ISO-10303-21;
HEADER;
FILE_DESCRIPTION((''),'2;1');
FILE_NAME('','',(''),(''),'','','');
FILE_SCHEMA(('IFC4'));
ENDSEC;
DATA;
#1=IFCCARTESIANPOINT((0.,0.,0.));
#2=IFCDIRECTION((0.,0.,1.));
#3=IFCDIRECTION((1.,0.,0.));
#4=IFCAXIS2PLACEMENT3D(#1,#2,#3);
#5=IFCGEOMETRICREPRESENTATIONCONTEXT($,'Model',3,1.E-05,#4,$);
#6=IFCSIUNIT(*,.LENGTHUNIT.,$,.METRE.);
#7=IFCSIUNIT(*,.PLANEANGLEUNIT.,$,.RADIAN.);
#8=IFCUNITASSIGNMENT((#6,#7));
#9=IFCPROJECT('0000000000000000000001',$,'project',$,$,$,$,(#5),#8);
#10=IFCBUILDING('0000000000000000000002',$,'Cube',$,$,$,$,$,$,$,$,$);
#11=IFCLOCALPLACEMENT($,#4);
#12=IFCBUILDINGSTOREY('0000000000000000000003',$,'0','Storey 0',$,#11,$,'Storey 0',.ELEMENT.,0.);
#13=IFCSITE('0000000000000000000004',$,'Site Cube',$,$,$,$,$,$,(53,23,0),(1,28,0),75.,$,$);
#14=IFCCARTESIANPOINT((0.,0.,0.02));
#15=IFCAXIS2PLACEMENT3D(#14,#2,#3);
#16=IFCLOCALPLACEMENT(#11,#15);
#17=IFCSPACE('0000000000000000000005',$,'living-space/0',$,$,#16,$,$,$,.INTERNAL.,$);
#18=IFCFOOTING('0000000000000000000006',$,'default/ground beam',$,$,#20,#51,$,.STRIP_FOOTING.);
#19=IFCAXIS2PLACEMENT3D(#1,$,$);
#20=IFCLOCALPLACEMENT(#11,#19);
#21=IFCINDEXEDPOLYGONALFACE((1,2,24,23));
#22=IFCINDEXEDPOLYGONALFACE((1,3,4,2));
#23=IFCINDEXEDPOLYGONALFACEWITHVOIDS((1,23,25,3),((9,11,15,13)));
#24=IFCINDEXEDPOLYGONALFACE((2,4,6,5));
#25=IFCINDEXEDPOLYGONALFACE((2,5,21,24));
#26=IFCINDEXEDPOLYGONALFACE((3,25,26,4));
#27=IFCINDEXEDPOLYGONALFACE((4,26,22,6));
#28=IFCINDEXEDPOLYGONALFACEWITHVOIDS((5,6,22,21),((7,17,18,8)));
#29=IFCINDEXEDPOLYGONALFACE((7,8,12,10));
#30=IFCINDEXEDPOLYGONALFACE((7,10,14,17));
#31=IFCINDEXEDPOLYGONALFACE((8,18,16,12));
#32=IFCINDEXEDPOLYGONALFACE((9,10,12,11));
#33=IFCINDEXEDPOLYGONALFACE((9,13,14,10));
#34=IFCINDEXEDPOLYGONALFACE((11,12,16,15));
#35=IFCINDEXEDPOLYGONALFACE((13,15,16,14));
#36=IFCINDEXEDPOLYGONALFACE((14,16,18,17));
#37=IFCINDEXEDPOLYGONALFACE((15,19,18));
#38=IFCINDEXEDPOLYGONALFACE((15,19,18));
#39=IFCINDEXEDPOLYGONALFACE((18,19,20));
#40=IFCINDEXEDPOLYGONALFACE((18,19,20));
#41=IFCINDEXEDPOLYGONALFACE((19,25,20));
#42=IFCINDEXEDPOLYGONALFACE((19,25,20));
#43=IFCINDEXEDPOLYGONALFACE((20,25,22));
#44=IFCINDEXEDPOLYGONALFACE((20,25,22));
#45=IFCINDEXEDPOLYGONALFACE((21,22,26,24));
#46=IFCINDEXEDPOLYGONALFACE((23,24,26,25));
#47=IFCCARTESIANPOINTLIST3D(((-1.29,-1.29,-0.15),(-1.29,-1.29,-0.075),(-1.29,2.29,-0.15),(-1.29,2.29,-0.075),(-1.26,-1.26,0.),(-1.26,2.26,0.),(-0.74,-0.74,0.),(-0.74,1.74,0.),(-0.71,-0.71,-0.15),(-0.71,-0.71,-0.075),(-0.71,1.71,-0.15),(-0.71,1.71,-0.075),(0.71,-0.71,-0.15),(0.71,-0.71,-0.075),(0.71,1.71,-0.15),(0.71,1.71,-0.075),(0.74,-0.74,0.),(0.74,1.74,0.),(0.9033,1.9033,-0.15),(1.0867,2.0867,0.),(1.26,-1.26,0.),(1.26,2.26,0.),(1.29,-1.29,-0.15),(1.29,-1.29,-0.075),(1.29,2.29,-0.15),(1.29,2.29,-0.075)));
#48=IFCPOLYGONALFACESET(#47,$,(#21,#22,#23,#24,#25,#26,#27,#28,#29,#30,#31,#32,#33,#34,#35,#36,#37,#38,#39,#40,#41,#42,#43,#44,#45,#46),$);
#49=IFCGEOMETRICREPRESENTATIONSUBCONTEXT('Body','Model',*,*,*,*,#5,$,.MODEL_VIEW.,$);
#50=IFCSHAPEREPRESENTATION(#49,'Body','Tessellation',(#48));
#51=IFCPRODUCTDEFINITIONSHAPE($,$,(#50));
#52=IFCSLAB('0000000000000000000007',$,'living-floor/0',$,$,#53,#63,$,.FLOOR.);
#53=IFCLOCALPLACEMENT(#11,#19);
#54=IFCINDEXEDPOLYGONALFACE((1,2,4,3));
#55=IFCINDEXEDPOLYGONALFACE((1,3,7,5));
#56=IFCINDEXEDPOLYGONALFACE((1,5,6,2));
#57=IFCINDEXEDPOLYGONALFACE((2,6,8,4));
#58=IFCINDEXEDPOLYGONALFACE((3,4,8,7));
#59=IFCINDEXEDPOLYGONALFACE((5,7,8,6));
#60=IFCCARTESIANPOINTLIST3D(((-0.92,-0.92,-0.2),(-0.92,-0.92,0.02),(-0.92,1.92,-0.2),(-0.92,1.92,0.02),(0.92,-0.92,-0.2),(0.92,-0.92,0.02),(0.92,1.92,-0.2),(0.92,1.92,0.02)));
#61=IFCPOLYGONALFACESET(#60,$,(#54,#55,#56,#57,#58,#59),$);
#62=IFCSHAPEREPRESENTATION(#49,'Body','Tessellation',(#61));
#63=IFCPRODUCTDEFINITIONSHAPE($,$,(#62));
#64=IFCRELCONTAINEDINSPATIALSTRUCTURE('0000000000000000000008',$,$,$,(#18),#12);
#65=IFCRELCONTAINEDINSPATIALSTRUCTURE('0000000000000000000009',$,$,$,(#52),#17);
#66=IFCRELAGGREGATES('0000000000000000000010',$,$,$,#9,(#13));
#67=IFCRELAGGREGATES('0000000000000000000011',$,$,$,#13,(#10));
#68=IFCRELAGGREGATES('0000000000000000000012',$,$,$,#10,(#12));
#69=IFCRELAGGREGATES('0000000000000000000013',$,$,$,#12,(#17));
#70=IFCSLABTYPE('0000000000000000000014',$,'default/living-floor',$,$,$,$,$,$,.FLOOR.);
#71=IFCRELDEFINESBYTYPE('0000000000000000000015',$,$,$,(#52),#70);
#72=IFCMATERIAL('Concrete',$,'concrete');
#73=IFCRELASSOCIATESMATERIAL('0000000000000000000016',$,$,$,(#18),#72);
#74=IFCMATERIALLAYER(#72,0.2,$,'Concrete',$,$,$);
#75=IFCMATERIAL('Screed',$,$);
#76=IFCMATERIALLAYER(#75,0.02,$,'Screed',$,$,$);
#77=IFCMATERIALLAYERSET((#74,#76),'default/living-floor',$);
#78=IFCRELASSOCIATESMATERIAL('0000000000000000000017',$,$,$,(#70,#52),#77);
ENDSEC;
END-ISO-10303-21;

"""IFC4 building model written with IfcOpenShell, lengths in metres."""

from ifc_helpers import new_model, entity, si_unit, frame, origin, origin_with_axes, place, context, subcontext, project, spatial, polyline, outline, extrude, material, layer, layer_set, layer_usage, type_object, element, save


model = new_model("IFC4")

# Units and contexts
model_context = context("Model", 3, precision=1e-05, world=origin_with_axes())
body_context = subcontext(model_context, "Body", "Model", "MODEL_VIEW")
ifc_project = project(units=[si_unit("LENGTHUNIT", "METRE"), si_unit("PLANEANGLEUNIT", "RADIAN")], contexts=[model_context])

# Site, building, storey
site = spatial("IfcSite", under=ifc_project, Name="Site Cube", RefLatitude=(53, 23, 0), RefLongitude=(1, 28, 0), RefElevation=75.0)
building = spatial("IfcBuilding", under=site, Name="Cube")
storey_placement = place(None, origin_with_axes())
storey = spatial("IfcBuildingStorey", under=building, at=storey_placement, Name="0", Description="Storey 0", LongName="Storey 0", CompositionType="ELEMENT", Elevation=0.0)

# Footing
ifc_material_1 = material(Name="Concrete", Category="concrete")
footing_placement = place(storey_placement, origin_with_axes())
axis2_placement3_d = entity("IfcAxis2Placement3D", entity("IfcCartesianPoint", [0.0, 0.0, 0.0]))
element("IfcFooting", 1, at=footing_placement, inside=storey, material=ifc_material_1, Name="default/ground beam", PredefinedType="STRIP_FOOTING", context=body_context, shape_type="AdvancedSweptSolid", body=[
    entity("IfcSurfaceCurveSweptAreaSolid", entity("IfcDerivedProfileDef", "AREA", None, entity("IfcArbitraryClosedProfileDef", "AREA", None, entity("IfcPolyline", [entity("IfcCartesianPoint", [0.0, -0.26]), entity("IfcCartesianPoint", [-0.075, -0.29]), entity("IfcCartesianPoint", [-0.15, -0.29]), entity("IfcCartesianPoint", [-0.15, 0.29]), entity("IfcCartesianPoint", [-0.075, 0.29]), entity("IfcCartesianPoint", [0.0, 0.26]), entity("IfcCartesianPoint", [0.0, -0.26])])), entity("IfcCartesianTransformationOperator2D", None, None, entity("IfcCartesianPoint", [0.0, 0.0]), 1.0)), axis2_placement3_d, entity("IfcPolyline", [entity("IfcCartesianPoint", [1.0, 2.0]), entity("IfcCartesianPoint", [-1.0, 2.0]), entity("IfcCartesianPoint", [-1.0, -1.0]), entity("IfcCartesianPoint", [1.0, -1.0]), entity("IfcCartesianPoint", [1.0, 2.0])]), 0.0, 1.0, entity("IfcPlane", axis2_placement3_d)),
])

# Shared definitions
space_placement = place(storey_placement, frame((0.0, 0.0, 0.02), z_axis=(0.0, 0.0, 1.0), x_axis=(1.0, 0.0, 0.0)))
space = spatial("IfcSpace", under=storey, at=space_placement, Name="living-space/0", PredefinedType="INTERNAL")

# Slab
ifc_layer_1 = layer(ifc_material_1, 0.2, Name="Concrete")
ifc_material_2 = material(Name="Screed")
ifc_layer_2 = layer(ifc_material_2, 0.02, Name="Screed")
ifc_layer_set_1 = layer_set([ifc_layer_1, ifc_layer_2], Name="default/living-floor")
ifc_layer_usage_1 = layer_usage(ifc_layer_set_1, "AXIS3", "POSITIVE", -0.2)
slab_type = type_object("IfcSlabType", Name="default/living-floor", PredefinedType="FLOOR", material=ifc_layer_set_1)
slab_placement = place(space_placement, frame((0.0, 0.0, -0.22), z_axis=(0.0, 0.0, 1.0), x_axis=(1.0, 0.0, 0.0)))
element("IfcSlab", 2, at=slab_placement, inside=space, type_object=slab_type, material=ifc_layer_usage_1, Name="living-floor/0", PredefinedType="FLOOR", context=body_context, shape_type="SweptSolid", body=[
    extrude(outline(polyline([(0.92, -0.92), (0.92, 1.92), (-0.92, 1.92), (-0.92, -0.92), (0.92, -0.92)])), origin(), (0.0, 0.0, 1.0), 0.22),
])

save(model, "model.ifc")
